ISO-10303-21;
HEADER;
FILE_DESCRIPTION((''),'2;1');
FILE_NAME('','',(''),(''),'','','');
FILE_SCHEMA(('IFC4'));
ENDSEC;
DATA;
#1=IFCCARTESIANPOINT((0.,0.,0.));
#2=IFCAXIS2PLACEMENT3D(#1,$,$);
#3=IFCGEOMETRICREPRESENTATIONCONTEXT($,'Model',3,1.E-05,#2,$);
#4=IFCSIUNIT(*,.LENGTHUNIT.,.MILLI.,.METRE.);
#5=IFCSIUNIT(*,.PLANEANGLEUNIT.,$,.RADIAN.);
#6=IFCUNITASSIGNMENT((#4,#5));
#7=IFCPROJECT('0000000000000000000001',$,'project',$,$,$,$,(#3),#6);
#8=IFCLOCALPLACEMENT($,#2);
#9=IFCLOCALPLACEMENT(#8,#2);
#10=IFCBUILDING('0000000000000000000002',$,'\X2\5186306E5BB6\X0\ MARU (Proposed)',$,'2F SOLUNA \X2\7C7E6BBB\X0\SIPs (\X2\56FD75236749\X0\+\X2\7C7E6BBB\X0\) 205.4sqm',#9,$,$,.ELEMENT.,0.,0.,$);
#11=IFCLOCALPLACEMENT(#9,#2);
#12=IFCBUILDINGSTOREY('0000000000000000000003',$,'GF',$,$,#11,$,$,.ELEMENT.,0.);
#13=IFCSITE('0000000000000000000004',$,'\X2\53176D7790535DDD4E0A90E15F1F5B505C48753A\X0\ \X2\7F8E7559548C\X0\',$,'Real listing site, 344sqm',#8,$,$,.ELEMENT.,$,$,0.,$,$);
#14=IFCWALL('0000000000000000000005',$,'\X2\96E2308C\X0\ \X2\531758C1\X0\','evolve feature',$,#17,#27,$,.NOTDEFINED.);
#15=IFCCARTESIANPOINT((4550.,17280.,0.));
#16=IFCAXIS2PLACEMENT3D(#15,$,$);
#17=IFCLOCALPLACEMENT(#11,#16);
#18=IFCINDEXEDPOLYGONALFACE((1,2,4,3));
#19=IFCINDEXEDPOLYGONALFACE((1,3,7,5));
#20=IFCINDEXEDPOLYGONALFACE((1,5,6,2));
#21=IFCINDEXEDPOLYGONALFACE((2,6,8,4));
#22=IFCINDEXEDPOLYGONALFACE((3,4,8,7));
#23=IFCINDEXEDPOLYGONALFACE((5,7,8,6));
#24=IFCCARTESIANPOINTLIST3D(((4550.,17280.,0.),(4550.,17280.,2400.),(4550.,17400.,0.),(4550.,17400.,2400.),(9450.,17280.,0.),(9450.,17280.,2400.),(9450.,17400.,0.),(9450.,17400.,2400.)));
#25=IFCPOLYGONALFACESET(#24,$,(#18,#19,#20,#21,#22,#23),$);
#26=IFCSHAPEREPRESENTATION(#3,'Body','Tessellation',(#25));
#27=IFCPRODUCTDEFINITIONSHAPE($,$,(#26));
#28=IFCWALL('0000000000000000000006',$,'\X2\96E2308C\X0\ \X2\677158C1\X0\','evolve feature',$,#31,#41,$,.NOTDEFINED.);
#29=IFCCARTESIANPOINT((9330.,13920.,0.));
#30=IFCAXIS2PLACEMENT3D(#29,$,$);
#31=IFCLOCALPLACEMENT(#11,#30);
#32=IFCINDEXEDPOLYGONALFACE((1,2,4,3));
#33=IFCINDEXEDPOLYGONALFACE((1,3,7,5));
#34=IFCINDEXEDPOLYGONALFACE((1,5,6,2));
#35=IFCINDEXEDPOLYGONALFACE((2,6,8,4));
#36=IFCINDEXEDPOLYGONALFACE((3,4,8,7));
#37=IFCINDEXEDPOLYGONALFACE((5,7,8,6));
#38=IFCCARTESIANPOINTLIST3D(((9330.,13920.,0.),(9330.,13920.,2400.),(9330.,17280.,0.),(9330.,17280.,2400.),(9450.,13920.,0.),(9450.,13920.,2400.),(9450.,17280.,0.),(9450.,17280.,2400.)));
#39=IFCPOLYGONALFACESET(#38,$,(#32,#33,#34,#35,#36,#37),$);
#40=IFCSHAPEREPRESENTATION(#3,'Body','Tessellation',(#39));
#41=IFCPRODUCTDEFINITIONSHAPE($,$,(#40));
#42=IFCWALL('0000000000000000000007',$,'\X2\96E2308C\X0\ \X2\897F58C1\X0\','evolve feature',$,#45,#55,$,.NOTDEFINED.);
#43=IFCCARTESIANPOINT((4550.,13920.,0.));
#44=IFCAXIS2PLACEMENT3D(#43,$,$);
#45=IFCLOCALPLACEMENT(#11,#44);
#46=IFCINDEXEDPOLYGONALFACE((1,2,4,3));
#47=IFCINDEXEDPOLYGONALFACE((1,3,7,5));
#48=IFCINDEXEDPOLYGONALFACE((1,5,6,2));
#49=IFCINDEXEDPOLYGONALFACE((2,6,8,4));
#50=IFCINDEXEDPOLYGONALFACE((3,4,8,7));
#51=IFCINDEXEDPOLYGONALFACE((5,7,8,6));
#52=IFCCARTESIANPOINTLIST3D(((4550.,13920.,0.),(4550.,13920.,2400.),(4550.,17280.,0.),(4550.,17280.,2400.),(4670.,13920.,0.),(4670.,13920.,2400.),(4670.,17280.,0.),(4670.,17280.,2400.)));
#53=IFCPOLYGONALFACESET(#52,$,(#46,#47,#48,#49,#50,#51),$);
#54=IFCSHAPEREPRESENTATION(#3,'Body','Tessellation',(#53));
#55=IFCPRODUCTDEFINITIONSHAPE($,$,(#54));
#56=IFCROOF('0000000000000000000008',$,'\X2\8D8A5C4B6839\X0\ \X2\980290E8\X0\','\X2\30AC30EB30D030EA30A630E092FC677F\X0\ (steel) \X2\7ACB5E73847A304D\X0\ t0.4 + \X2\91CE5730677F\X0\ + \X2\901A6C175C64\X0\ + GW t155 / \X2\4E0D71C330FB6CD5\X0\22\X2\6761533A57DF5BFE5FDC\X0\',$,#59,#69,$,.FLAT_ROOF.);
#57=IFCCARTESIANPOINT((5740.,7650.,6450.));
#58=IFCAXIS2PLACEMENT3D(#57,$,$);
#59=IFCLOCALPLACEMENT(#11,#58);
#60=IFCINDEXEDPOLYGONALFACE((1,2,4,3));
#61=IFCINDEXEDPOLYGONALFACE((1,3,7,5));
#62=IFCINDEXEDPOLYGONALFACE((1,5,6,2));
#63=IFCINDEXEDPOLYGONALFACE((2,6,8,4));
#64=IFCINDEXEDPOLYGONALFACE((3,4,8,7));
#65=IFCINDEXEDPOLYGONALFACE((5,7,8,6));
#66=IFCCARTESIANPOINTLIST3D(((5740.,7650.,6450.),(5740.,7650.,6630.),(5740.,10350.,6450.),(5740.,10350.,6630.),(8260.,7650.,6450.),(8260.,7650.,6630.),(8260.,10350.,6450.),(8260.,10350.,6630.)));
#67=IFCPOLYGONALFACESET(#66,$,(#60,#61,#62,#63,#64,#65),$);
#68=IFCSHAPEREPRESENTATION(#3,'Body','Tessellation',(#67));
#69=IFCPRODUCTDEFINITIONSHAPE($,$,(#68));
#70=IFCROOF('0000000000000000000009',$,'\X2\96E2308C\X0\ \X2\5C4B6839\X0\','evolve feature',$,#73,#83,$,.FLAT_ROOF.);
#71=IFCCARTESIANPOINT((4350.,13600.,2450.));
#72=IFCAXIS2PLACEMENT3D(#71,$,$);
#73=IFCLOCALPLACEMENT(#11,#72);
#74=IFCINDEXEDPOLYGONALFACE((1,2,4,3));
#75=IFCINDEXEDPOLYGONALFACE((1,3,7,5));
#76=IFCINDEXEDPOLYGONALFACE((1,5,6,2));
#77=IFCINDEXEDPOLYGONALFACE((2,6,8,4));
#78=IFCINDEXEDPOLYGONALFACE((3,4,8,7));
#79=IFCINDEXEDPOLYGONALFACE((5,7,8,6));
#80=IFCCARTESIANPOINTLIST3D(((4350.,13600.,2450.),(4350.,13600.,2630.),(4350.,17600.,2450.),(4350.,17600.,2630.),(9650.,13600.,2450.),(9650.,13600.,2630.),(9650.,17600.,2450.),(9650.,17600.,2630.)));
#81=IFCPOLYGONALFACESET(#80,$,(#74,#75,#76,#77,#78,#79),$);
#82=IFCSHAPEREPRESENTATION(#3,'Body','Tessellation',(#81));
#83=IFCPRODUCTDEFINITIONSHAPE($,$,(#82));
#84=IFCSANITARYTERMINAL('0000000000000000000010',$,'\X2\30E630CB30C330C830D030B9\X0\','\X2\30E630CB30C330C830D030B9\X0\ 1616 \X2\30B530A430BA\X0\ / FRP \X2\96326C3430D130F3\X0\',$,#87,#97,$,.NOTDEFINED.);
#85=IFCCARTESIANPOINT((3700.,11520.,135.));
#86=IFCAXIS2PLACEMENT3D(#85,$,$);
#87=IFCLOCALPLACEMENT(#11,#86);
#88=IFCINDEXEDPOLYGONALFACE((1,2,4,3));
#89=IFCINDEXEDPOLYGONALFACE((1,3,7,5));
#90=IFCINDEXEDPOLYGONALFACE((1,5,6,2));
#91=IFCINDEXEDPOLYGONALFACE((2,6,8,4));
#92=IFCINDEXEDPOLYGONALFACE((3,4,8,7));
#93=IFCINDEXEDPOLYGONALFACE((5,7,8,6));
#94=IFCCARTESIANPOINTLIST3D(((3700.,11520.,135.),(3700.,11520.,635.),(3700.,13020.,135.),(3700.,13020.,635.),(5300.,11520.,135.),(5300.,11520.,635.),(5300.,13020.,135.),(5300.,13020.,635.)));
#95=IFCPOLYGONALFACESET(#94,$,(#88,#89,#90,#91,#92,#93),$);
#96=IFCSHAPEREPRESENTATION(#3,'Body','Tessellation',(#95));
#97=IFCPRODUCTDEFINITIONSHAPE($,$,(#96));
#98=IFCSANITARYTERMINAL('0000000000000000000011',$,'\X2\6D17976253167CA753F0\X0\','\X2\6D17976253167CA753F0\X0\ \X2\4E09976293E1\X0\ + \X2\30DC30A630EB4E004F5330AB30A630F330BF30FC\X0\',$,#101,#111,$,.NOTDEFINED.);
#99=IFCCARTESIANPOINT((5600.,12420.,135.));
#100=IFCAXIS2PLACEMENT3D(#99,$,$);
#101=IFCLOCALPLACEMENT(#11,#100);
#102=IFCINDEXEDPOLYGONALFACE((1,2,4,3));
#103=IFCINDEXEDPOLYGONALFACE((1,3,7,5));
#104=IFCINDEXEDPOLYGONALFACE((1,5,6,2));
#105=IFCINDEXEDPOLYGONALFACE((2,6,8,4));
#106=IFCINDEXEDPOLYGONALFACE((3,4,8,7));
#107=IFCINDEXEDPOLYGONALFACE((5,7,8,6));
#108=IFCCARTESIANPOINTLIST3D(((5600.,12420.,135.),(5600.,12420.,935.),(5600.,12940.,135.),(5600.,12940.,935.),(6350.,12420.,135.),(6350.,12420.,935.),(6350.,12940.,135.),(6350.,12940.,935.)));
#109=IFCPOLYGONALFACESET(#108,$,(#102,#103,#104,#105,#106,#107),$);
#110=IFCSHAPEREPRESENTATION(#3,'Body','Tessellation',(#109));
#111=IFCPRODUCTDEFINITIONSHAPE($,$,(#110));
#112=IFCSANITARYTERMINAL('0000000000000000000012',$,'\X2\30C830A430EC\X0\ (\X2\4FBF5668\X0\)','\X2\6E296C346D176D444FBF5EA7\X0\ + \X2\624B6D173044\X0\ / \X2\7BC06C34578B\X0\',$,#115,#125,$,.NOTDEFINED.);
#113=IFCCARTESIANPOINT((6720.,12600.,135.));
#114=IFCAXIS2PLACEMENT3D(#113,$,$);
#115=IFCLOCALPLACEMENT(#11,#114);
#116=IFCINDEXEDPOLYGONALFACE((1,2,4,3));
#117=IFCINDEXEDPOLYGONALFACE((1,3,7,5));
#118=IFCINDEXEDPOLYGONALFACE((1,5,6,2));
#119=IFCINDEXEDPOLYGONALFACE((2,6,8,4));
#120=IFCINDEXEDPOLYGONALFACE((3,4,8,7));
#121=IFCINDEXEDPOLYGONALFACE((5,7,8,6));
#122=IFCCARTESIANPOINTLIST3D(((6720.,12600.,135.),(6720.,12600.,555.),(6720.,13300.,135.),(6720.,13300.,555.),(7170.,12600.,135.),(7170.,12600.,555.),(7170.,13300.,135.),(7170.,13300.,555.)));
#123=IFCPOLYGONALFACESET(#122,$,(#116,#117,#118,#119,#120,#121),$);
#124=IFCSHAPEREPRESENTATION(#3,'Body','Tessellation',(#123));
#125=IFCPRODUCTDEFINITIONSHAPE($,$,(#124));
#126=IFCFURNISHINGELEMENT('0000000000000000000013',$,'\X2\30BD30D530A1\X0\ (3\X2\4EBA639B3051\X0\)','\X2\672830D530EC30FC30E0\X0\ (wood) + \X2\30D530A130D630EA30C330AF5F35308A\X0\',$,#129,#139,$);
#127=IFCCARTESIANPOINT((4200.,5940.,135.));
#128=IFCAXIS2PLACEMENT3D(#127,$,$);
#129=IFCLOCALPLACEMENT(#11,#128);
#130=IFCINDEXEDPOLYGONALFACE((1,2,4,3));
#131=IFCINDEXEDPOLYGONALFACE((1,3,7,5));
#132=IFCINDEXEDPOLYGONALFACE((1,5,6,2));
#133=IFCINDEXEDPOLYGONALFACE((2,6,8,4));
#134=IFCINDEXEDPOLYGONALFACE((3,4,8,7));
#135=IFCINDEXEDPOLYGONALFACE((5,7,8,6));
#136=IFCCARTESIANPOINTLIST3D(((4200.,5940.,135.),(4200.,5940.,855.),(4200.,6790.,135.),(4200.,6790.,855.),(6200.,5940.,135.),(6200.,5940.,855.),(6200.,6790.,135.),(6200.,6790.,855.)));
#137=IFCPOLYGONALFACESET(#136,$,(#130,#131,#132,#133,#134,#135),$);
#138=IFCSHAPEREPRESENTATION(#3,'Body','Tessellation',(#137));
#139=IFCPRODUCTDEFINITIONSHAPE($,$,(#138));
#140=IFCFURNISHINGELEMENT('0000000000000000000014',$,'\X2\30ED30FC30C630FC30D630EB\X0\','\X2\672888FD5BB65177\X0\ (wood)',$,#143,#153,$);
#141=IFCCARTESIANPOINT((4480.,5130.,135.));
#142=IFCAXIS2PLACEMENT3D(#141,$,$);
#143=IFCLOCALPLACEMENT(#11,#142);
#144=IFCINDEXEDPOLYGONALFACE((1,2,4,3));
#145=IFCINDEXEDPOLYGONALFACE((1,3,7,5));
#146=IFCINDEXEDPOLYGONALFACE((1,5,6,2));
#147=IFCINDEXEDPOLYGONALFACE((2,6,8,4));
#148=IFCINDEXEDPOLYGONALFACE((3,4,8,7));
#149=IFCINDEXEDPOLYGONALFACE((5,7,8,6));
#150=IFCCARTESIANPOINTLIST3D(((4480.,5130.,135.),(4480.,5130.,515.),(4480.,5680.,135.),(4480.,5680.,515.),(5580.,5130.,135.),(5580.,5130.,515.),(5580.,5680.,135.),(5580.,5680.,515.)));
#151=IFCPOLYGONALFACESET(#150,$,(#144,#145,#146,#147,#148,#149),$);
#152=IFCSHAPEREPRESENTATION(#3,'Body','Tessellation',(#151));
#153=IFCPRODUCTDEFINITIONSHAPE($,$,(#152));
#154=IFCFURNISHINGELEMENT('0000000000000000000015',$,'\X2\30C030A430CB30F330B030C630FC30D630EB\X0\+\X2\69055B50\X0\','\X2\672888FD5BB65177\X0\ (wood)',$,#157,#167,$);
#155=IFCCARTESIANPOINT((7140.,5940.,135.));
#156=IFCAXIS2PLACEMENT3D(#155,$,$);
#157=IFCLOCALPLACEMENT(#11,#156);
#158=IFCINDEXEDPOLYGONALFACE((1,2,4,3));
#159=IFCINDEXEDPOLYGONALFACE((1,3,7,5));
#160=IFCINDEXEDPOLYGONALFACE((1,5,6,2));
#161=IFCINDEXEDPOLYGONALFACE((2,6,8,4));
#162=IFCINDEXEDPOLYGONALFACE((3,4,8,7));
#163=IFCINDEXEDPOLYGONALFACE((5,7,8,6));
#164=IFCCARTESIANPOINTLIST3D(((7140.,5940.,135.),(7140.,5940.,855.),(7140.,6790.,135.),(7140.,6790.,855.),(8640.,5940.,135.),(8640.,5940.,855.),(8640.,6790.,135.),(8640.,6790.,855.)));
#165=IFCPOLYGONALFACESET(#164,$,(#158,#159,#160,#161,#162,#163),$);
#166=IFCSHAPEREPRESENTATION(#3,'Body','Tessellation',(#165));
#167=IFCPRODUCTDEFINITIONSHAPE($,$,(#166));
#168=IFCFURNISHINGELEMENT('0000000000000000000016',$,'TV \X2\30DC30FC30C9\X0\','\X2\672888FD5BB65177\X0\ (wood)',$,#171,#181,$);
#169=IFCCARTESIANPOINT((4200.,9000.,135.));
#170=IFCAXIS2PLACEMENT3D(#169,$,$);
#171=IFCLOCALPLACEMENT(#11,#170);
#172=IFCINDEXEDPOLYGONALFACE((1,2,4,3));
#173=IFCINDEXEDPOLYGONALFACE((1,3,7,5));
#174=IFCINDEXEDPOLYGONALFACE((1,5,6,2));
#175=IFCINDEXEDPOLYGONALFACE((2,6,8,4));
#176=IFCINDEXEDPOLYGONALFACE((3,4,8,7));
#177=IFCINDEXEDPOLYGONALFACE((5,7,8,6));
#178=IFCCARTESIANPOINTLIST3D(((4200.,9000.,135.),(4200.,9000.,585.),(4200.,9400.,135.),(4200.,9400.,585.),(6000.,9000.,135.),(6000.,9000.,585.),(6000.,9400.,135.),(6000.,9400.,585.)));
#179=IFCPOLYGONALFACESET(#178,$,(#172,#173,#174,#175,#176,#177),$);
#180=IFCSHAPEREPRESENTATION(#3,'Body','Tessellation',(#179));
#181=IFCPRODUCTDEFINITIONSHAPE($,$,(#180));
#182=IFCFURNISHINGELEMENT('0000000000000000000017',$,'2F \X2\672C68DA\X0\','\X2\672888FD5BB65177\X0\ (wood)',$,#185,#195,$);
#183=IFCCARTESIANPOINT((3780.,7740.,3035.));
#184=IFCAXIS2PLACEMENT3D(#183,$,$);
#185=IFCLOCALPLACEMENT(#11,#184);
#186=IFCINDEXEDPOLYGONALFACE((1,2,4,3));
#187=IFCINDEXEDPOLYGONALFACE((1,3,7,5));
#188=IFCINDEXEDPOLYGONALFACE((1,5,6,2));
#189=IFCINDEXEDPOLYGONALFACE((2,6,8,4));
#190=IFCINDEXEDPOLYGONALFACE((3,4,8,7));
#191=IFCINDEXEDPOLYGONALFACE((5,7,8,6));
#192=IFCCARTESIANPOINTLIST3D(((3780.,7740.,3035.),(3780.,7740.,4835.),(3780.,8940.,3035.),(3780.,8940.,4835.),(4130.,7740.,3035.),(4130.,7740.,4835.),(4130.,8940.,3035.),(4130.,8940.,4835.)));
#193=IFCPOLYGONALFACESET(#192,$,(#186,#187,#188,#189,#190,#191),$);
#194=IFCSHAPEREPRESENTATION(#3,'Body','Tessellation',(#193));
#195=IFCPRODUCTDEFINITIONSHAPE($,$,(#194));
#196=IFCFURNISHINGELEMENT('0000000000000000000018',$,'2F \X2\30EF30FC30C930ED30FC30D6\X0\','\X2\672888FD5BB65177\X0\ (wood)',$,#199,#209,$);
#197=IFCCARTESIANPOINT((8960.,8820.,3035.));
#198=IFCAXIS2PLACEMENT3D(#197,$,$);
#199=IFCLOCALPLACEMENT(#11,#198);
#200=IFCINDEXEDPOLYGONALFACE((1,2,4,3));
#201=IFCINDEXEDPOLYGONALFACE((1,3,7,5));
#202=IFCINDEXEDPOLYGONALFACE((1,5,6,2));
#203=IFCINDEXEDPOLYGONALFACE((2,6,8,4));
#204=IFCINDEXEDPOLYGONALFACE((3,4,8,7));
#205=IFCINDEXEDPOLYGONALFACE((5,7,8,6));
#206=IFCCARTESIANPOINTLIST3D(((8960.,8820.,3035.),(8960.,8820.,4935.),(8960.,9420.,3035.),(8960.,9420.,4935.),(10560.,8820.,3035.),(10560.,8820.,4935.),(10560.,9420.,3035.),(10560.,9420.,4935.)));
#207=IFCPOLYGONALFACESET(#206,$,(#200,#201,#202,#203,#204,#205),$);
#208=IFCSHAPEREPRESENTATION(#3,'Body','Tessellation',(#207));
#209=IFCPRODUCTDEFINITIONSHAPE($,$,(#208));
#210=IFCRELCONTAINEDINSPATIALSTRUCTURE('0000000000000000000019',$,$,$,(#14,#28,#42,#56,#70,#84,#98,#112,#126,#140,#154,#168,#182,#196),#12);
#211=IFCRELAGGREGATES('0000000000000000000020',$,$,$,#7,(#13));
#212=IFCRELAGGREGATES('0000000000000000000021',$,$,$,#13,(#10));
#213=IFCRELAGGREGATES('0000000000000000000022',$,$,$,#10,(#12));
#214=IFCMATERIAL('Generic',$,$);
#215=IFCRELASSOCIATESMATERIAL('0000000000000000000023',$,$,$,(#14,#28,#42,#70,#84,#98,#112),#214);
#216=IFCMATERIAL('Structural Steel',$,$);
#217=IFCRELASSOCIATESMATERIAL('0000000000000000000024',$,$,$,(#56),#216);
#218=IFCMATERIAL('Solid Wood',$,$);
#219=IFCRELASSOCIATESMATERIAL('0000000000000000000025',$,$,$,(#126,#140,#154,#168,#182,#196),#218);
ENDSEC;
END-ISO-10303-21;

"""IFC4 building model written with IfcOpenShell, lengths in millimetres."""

from ifc_helpers import new_model, si_unit, frame, frame_2d, origin, place, context, project, spatial, rectangle, extrude, material, element, save


model = new_model("IFC4")

# Units and contexts
model_context = context("Model", 3, precision=1e-05, world=origin())
ifc_project = project(units=[si_unit("LENGTHUNIT", "METRE", prefix="MILLI"), si_unit("PLANEANGLEUNIT", "RADIAN")], contexts=[model_context])

# Site, building, storey
site_placement = place(None, origin())
site = spatial("IfcSite", under=ifc_project, at=site_placement, Name="北海道川上郡弟子屈町 美留和", ObjectType="Real listing site, 344sqm", CompositionType="ELEMENT", RefElevation=0.0)
building_placement = place(site_placement, origin())
building = spatial("IfcBuilding", under=site, at=building_placement, Name="円の家 MARU (Proposed)", ObjectType="2F SOLUNA 籾殻SIPs (国産杉+籾殻) 205.4sqm", CompositionType="ELEMENT", ElevationOfRefHeight=0.0, ElevationOfTerrain=0.0)
storey_placement = place(building_placement, origin())
storey = spatial("IfcBuildingStorey", under=building, at=storey_placement, Name="GF", CompositionType="ELEMENT", Elevation=0.0)

# Shared definitions
ifc_material_1 = material(Name="Generic")

# Shared definitions
ifc_material_2 = material(Name="Solid Wood")

# Walls
wall_1_placement = place(storey_placement, frame((4550.0, 17280.0, 0.0)))
element("IfcWall", 1, at=wall_1_placement, inside=storey, material=ifc_material_1, Name="離れ 北壁", Description="evolve feature", PredefinedType="NOTDEFINED", context=model_context, shape_type="SweptSolid", body=[
    extrude(rectangle(XDim=4900.0, YDim=120.0, at=frame_2d((2450.0, 60.0))), frame((4550.0, 17280.0, 0.0)), (0.0, 0.0, 1.0), 2400.0),
])
wall_2_placement = place(storey_placement, frame((9330.0, 13920.0, 0.0)))
element("IfcWall", 2, at=wall_2_placement, inside=storey, material=ifc_material_1, Name="離れ 東壁", Description="evolve feature", PredefinedType="NOTDEFINED", context=model_context, shape_type="SweptSolid", body=[
    extrude(rectangle(XDim=120.0, YDim=3360.0, at=frame_2d((60.0, 1680.0))), frame((9330.0, 13920.0, 0.0)), (0.0, 0.0, 1.0), 2400.0),
])
wall_3_placement = place(storey_placement, frame((4550.0, 13920.0, 0.0)))
element("IfcWall", 3, at=wall_3_placement, inside=storey, material=ifc_material_1, Name="離れ 西壁", Description="evolve feature", PredefinedType="NOTDEFINED", context=model_context, shape_type="SweptSolid", body=[
    extrude(rectangle(XDim=120.0, YDim=3360.0, at=frame_2d((60.0, 1680.0))), frame((4550.0, 13920.0, 0.0)), (0.0, 0.0, 1.0), 2400.0),
])

# Roofs
ifc_material_3 = material(Name="Structural Steel")
roof_1_placement = place(storey_placement, frame((5740.0, 7650.0, 6450.0)))
element("IfcRoof", 4, at=roof_1_placement, inside=storey, material=ifc_material_3, Name="越屋根 頂部", Description="ガルバリウム鋼板 (steel) 立平葺き t0.4 + 野地板 + 通気層 + GW t155 / 不燃・法22条区域対応", PredefinedType="FLAT_ROOF", context=model_context, shape_type="SweptSolid", body=[
    extrude(rectangle(XDim=2520.0, YDim=2700.0, at=frame_2d((1260.0, 1350.0))), frame((5740.0, 7650.0, 6450.0)), (0.0, 0.0, 1.0), 180.0),
])
roof_2_placement = place(storey_placement, frame((4350.0, 13600.0, 2450.0)))
element("IfcRoof", 5, at=roof_2_placement, inside=storey, material=ifc_material_1, Name="離れ 屋根", Description="evolve feature", PredefinedType="FLAT_ROOF", context=model_context, shape_type="SweptSolid", body=[
    extrude(rectangle(XDim=5300.0, YDim=4000.0, at=frame_2d((2650.0, 2000.0))), frame((4350.0, 13600.0, 2450.0)), (0.0, 0.0, 1.0), 180.0),
])

# Sanitary terminals
sanitary_terminal_1_placement = place(storey_placement, frame((3700.0, 11520.0, 135.0)))
element("IfcSanitaryTerminal", 6, at=sanitary_terminal_1_placement, inside=storey, material=ifc_material_1, Name="ユニットバス", Description="ユニットバス 1616 サイズ / FRP 防水パン", PredefinedType="NOTDEFINED", context=model_context, shape_type="SweptSolid", body=[
    extrude(rectangle(XDim=1600.0, YDim=1500.0, at=frame_2d((800.0, 750.0))), frame((3700.0, 11520.0, 135.0)), (0.0, 0.0, 1.0), 500.0),
])
sanitary_terminal_2_placement = place(storey_placement, frame((5600.0, 12420.0, 135.0)))
element("IfcSanitaryTerminal", 7, at=sanitary_terminal_2_placement, inside=storey, material=ifc_material_1, Name="洗面化粧台", Description="洗面化粧台 三面鏡 + ボウル一体カウンター", PredefinedType="NOTDEFINED", context=model_context, shape_type="SweptSolid", body=[
    extrude(rectangle(XDim=750.0, YDim=520.0, at=frame_2d((375.0, 260.0))), frame((5600.0, 12420.0, 135.0)), (0.0, 0.0, 1.0), 800.0),
])
sanitary_terminal_3_placement = place(storey_placement, frame((6720.0, 12600.0, 135.0)))
element("IfcSanitaryTerminal", 8, at=sanitary_terminal_3_placement, inside=storey, material=ifc_material_1, Name="トイレ (便器)", Description="温水洗浄便座 + 手洗い / 節水型", PredefinedType="NOTDEFINED", context=model_context, shape_type="SweptSolid", body=[
    extrude(rectangle(XDim=450.0, YDim=700.0, at=frame_2d((225.0, 350.0))), frame((6720.0, 12600.0, 135.0)), (0.0, 0.0, 1.0), 420.0),
])

# Furnishing elements
furnishing_1_placement = place(storey_placement, frame((4200.0, 5940.0, 135.0)))
element("IfcFurnishingElement", 9, at=furnishing_1_placement, inside=storey, material=ifc_material_2, Name="ソファ (3人掛け)", Description="木フレーム (wood) + ファブリック張り", context=model_context, shape_type="SweptSolid", body=[
    extrude(rectangle(XDim=2000.0, YDim=850.0, at=frame_2d((1000.0, 425.0))), frame((4200.0, 5940.0, 135.0)), (0.0, 0.0, 1.0), 720.0),
])
furnishing_2_placement = place(storey_placement, frame((4480.0, 5130.0, 135.0)))
element("IfcFurnishingElement", 10, at=furnishing_2_placement, inside=storey, material=ifc_material_2, Name="ローテーブル", Description="木製家具 (wood)", context=model_context, shape_type="SweptSolid", body=[
    extrude(rectangle(XDim=1100.0, YDim=550.0, at=frame_2d((550.0, 275.0))), frame((4480.0, 5130.0, 135.0)), (0.0, 0.0, 1.0), 380.0),
])
furnishing_3_placement = place(storey_placement, frame((7140.0, 5940.0, 135.0)))
element("IfcFurnishingElement", 11, at=furnishing_3_placement, inside=storey, material=ifc_material_2, Name="ダイニングテーブル+椅子", Description="木製家具 (wood)", context=model_context, shape_type="SweptSolid", body=[
    extrude(rectangle(XDim=1500.0, YDim=850.0, at=frame_2d((750.0, 425.0))), frame((7140.0, 5940.0, 135.0)), (0.0, 0.0, 1.0), 720.0),
])
furnishing_4_placement = place(storey_placement, frame((4200.0, 9000.0, 135.0)))
element("IfcFurnishingElement", 12, at=furnishing_4_placement, inside=storey, material=ifc_material_2, Name="TV ボード", Description="木製家具 (wood)", context=model_context, shape_type="SweptSolid", body=[
    extrude(rectangle(XDim=1800.0, YDim=400.0, at=frame_2d((900.0, 200.0))), frame((4200.0, 9000.0, 135.0)), (0.0, 0.0, 1.0), 450.0),
])
furnishing_5_placement = place(storey_placement, frame((3780.0, 7740.0, 3035.0)))
element("IfcFurnishingElement", 13, at=furnishing_5_placement, inside=storey, material=ifc_material_2, Name="2F 本棚", Description="木製家具 (wood)", context=model_context, shape_type="SweptSolid", body=[
    extrude(rectangle(XDim=350.0, YDim=1200.0, at=frame_2d((175.0, 600.0))), frame((3780.0, 7740.0, 3035.0)), (0.0, 0.0, 1.0), 1800.0),
])
furnishing_6_placement = place(storey_placement, frame((8960.0, 8820.0, 3035.0)))
element("IfcFurnishingElement", 14, at=furnishing_6_placement, inside=storey, material=ifc_material_2, Name="2F ワードローブ", Description="木製家具 (wood)", context=model_context, shape_type="SweptSolid", body=[
    extrude(rectangle(XDim=1600.0, YDim=600.0, at=frame_2d((800.0, 300.0))), frame((8960.0, 8820.0, 3035.0)), (0.0, 0.0, 1.0), 1900.0),
])

save(model, "model.ifc")
